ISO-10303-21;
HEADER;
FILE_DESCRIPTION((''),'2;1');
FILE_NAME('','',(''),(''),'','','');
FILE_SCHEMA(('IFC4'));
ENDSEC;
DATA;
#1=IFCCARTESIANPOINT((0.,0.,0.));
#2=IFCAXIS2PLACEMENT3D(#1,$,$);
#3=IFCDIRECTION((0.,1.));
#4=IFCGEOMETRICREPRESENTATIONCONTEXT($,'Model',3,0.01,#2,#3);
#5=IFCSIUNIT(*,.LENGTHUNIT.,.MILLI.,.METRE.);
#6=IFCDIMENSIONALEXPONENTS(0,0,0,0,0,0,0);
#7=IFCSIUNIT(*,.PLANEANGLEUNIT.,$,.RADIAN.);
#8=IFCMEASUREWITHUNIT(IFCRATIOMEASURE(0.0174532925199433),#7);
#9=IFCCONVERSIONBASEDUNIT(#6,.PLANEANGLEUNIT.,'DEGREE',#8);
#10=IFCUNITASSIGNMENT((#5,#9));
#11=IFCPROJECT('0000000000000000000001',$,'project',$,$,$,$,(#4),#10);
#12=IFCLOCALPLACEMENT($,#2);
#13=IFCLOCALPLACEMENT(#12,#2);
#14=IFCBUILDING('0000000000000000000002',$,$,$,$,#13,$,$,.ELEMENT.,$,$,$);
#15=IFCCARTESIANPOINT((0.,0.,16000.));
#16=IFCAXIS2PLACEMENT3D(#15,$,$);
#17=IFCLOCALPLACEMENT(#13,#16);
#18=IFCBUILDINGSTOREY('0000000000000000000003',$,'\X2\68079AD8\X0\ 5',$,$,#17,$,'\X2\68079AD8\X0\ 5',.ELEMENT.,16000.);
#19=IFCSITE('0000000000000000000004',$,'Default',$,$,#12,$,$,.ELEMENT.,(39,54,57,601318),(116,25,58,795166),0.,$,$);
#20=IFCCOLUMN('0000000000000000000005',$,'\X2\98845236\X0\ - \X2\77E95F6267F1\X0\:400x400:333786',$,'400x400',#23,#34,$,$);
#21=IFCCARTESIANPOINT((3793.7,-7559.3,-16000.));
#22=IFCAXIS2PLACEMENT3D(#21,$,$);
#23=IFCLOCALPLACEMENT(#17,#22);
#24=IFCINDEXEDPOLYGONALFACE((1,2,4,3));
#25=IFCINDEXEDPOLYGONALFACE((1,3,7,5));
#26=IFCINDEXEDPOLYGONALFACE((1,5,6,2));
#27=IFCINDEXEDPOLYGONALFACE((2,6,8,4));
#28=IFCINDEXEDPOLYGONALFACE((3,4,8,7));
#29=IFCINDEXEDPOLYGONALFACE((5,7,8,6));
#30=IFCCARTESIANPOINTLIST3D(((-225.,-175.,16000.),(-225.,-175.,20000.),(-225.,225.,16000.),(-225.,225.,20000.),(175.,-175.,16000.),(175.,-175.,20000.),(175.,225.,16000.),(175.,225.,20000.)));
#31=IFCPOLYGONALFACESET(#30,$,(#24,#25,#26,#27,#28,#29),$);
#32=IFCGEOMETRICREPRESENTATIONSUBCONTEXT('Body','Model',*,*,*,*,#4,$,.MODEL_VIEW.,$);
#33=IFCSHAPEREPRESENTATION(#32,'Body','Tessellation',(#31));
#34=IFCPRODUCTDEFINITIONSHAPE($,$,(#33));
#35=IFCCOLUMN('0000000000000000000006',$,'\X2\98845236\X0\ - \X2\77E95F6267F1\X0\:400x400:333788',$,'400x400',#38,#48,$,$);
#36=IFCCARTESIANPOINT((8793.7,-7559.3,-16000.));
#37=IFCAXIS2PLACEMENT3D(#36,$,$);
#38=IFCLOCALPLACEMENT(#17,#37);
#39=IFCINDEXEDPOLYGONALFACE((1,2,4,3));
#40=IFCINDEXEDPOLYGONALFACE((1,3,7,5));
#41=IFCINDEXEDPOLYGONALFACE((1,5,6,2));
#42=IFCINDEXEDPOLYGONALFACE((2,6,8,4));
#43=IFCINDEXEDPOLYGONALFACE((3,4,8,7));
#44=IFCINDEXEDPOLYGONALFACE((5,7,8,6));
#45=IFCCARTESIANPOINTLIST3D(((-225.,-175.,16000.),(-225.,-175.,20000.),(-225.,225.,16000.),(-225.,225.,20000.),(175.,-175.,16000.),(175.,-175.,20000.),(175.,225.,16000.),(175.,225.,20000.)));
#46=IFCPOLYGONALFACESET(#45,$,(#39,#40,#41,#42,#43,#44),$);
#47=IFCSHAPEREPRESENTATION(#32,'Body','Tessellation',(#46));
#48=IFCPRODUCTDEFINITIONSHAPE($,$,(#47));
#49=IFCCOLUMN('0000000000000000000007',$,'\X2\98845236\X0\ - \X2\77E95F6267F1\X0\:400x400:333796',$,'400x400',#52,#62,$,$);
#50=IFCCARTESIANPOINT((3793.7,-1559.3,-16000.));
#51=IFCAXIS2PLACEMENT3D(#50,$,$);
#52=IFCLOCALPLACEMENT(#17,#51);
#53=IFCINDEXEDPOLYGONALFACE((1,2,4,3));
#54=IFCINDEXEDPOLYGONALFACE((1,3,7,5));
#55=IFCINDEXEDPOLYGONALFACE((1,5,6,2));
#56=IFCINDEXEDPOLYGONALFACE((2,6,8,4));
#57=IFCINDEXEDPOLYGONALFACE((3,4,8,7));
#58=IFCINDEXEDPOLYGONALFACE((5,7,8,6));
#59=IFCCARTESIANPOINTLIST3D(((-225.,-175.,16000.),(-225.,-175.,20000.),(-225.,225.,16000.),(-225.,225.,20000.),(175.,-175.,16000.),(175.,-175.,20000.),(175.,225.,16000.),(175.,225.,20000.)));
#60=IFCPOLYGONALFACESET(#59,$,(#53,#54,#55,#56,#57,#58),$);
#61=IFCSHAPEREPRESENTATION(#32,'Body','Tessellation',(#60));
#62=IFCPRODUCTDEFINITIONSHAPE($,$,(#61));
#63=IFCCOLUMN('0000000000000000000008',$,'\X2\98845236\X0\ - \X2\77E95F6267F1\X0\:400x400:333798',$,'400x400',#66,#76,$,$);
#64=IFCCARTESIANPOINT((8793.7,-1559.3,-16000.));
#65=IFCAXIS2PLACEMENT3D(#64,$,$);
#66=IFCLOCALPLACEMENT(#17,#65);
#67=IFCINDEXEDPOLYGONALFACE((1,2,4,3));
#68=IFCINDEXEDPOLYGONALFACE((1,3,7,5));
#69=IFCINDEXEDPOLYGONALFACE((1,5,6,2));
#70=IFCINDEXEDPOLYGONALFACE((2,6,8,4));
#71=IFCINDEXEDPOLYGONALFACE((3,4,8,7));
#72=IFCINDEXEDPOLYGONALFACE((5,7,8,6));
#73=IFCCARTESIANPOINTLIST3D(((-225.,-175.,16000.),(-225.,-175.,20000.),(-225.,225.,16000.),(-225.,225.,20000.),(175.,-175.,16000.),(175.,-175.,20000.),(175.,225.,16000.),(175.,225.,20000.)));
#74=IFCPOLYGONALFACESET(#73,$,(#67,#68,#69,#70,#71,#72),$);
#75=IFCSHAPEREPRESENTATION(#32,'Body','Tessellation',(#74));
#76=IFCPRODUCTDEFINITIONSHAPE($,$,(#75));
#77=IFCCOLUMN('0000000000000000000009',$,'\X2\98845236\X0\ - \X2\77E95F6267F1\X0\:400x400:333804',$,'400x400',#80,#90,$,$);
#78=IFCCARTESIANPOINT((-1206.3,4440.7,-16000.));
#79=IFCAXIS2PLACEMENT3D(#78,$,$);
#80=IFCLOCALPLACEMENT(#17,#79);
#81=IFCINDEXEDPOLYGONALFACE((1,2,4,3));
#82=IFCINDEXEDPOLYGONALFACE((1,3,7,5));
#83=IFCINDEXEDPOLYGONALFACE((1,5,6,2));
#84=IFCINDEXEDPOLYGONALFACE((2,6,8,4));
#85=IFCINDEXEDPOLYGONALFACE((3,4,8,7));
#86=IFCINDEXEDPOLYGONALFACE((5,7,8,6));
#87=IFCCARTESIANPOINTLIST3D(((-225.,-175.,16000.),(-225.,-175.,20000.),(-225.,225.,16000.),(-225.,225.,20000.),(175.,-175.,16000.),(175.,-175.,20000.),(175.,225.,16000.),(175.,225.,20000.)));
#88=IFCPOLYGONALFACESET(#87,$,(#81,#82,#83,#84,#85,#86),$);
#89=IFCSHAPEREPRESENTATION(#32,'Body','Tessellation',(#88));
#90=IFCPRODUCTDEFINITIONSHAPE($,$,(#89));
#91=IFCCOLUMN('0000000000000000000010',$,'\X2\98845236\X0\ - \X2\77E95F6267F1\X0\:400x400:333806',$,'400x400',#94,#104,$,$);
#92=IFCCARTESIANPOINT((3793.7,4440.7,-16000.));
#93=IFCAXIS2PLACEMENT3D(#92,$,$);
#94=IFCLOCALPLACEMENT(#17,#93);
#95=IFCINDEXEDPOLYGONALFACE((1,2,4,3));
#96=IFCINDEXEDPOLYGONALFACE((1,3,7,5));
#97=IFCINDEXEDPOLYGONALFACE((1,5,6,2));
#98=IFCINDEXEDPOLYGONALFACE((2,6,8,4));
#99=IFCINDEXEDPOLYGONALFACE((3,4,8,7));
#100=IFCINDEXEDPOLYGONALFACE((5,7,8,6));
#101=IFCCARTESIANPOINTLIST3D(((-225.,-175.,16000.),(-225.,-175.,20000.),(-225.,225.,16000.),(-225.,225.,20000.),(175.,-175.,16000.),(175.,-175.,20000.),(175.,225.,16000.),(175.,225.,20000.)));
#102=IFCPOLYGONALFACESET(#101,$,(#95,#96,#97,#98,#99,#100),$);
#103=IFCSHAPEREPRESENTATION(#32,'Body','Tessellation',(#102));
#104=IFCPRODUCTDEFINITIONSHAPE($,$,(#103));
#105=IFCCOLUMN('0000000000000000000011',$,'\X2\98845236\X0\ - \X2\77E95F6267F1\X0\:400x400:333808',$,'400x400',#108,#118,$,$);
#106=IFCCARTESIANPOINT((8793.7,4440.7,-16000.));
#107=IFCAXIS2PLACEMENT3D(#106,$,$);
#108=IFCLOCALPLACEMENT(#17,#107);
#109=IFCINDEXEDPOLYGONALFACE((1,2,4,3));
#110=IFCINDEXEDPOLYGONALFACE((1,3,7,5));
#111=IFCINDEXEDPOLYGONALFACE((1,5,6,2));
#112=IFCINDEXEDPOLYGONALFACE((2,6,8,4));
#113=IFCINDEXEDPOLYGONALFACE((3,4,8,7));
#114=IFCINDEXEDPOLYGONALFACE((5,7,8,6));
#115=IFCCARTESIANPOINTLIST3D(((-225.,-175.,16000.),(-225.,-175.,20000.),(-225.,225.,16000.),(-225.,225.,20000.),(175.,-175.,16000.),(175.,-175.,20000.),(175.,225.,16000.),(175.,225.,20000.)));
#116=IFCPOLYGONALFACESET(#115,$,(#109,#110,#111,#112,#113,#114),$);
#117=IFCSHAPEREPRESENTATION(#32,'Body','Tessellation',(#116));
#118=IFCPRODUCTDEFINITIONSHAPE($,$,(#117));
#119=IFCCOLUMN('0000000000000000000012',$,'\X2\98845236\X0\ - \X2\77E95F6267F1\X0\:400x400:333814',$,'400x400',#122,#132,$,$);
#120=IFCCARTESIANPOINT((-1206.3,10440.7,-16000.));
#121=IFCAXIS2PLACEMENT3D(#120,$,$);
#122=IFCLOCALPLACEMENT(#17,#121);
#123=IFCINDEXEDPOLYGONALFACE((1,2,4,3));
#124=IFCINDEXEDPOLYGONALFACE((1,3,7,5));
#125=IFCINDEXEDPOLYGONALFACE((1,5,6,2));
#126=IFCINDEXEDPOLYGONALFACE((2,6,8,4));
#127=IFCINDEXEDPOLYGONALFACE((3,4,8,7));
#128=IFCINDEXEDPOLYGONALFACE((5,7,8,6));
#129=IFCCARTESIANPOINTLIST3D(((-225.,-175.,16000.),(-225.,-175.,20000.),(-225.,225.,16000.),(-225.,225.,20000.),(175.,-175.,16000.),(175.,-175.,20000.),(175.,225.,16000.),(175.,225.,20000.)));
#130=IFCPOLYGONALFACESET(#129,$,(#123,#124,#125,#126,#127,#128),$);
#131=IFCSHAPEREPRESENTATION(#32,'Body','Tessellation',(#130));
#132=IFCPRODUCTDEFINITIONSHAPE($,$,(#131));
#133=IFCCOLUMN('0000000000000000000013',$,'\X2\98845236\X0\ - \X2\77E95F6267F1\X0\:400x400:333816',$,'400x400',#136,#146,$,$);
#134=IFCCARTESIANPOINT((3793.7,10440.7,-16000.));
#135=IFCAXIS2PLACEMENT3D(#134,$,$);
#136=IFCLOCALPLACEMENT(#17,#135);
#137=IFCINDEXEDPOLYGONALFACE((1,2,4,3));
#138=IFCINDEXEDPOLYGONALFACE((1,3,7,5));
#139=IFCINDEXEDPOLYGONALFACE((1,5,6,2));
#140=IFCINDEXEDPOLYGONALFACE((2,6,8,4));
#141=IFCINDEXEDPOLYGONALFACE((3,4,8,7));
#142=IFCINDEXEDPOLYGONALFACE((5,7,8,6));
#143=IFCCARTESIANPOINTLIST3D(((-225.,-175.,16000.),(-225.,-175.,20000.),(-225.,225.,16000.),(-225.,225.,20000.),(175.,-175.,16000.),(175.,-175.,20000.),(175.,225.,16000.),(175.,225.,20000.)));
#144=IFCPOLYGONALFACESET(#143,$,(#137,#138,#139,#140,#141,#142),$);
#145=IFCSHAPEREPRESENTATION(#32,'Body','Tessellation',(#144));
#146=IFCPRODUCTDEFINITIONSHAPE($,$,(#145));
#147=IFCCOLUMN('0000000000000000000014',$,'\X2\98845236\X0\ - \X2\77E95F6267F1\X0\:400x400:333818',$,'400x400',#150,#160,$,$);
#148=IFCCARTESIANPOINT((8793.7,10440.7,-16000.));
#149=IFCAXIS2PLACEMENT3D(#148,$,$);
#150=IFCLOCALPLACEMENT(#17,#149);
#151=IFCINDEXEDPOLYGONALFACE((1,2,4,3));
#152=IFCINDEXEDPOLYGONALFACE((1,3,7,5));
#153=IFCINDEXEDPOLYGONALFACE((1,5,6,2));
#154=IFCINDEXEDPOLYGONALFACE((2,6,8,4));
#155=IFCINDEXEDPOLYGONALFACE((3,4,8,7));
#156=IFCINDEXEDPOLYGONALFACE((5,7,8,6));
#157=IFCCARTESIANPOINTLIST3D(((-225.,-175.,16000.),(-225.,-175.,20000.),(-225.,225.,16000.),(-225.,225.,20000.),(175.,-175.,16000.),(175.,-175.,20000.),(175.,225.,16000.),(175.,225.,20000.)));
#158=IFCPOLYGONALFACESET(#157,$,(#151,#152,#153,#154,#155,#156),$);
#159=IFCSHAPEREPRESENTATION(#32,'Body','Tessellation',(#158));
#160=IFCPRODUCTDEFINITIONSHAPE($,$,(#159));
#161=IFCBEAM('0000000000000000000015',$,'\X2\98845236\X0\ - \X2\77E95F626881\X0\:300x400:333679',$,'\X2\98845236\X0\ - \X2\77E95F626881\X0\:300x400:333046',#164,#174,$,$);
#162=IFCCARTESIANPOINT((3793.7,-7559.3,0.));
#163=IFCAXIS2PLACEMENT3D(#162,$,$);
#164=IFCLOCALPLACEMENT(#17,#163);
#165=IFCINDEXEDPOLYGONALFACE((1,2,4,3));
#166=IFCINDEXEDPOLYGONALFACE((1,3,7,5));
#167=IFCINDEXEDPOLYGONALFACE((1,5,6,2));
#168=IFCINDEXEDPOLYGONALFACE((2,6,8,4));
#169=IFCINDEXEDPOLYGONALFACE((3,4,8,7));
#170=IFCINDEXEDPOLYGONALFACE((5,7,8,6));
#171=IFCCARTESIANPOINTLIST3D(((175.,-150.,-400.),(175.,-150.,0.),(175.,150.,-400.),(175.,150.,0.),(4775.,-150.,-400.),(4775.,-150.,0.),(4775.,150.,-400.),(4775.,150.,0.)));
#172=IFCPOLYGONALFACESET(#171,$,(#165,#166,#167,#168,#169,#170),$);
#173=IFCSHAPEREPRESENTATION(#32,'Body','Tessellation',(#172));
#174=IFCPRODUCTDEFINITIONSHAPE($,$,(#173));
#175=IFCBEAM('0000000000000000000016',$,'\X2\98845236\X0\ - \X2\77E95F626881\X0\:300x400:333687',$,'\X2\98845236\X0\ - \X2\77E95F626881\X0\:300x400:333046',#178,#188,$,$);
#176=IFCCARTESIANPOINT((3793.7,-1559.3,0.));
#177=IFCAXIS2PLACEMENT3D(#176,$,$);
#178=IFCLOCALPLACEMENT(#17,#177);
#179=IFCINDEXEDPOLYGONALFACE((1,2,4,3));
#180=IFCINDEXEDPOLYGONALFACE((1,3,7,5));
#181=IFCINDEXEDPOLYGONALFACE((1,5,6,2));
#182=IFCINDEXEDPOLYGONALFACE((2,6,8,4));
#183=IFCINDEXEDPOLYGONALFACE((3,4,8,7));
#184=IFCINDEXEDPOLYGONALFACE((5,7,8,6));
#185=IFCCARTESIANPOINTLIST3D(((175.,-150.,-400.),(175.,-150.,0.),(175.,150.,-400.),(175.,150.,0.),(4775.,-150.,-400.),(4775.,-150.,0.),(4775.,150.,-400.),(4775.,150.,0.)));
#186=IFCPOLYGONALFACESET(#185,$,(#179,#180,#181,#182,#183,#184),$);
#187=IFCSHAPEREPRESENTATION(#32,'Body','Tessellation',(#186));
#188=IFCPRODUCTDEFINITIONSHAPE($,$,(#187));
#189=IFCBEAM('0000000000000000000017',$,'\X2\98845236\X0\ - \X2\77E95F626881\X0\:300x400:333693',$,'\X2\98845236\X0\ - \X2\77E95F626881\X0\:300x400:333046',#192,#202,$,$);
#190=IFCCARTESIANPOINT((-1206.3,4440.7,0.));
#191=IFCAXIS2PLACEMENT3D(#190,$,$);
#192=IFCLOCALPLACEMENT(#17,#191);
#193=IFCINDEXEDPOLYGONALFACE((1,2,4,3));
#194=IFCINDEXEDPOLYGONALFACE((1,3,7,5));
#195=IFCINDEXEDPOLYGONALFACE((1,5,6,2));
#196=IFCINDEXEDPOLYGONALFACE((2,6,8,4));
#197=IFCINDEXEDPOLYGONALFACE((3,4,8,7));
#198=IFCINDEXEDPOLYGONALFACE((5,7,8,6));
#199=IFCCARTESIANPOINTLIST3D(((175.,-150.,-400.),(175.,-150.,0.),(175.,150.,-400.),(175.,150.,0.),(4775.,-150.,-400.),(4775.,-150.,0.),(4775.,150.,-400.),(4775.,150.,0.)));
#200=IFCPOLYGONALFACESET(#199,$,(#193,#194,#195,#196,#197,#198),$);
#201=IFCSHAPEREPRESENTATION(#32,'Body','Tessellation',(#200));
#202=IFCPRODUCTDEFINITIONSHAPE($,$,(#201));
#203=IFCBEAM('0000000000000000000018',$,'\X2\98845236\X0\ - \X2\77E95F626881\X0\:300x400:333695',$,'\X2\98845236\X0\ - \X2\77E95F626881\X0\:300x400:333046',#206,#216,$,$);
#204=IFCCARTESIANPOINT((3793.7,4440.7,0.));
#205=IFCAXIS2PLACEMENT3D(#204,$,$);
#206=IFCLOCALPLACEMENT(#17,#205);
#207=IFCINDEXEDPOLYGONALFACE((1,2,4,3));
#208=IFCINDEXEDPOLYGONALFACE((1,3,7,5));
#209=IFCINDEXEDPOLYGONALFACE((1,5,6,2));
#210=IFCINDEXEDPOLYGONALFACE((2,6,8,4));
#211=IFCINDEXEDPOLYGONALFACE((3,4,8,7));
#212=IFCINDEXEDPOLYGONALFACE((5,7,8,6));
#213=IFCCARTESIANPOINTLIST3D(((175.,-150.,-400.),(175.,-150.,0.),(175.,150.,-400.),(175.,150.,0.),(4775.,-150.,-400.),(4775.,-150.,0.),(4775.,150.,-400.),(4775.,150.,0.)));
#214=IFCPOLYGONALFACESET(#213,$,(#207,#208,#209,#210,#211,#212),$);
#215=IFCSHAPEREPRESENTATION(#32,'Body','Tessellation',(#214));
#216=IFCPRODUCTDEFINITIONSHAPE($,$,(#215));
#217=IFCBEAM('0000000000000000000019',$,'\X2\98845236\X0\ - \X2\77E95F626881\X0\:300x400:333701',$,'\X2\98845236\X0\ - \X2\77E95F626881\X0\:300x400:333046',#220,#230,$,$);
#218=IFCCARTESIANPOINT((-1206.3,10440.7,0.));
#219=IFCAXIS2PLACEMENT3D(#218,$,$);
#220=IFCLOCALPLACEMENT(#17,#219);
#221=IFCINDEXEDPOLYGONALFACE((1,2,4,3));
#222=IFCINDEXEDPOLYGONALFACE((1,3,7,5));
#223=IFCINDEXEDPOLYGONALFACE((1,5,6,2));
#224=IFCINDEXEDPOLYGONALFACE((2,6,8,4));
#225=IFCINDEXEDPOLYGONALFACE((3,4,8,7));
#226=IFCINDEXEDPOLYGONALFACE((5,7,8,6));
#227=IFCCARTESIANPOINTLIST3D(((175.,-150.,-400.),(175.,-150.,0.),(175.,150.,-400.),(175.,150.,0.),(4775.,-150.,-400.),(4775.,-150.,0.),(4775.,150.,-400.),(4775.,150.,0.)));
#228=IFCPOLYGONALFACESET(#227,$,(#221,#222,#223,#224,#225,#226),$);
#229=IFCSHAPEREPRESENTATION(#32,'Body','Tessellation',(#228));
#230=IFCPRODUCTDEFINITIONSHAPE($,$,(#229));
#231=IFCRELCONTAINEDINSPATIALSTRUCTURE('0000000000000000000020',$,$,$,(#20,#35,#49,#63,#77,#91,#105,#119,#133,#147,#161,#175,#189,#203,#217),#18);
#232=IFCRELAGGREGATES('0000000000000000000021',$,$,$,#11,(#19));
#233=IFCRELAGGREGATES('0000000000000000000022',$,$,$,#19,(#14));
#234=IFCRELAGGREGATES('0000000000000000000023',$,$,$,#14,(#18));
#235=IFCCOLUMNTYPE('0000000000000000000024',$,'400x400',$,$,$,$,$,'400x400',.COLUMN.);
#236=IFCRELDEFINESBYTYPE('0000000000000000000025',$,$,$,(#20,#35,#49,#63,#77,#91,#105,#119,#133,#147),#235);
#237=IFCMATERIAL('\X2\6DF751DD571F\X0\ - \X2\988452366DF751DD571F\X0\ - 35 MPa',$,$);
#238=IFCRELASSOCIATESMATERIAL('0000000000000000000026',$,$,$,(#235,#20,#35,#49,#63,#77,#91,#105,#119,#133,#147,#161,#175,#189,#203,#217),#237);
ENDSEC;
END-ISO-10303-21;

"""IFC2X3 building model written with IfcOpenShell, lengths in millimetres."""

from ifc_helpers import new_model, entity, si_unit, converted_unit, direction, frame, frame_2d, origin, place, context, subcontext, project, spatial, rectangle, extrude, source, transform, mapped, material, type_object, type_shapes, element, save


model = new_model("IFC2X3")

# Units and contexts
model_context = context("Model", 3, precision=0.01, world=origin(), true_north=direction((0.0, 1.0)))
body_context = subcontext(model_context, "Body", "Model", "MODEL_VIEW")
ifc_project = project(units=[si_unit("LENGTHUNIT", "METRE", prefix="MILLI"), converted_unit("PLANEANGLEUNIT", "DEGREE", entity("IfcRatioMeasure", 0.0174532925199433), si_unit("PLANEANGLEUNIT", "RADIAN"), dimensions=[0, 0, 0, 0, 0, 0, 0])], contexts=[model_context])

# Site, building, storey
site_placement = place(None, origin())
site = spatial("IfcSite", under=ifc_project, at=site_placement, Name="Default", CompositionType="ELEMENT", RefLatitude=(39, 54, 57, 601318), RefLongitude=(116, 25, 58, 795166), RefElevation=0.0)
building_placement = place(site_placement, origin())
building = spatial("IfcBuilding", under=site, at=building_placement, CompositionType="ELEMENT")
storey_placement = place(building_placement, frame((0.0, 0.0, 16000.0)))
storey = spatial("IfcBuildingStorey", under=building, at=storey_placement, Name="标高 5", LongName="标高 5", CompositionType="ELEMENT", Elevation=16000.0)

# Columns
ifc_material_1 = material(Name="混凝土 - 预制混凝土 - 35 MPa")
column_type = type_object("IfcColumnType", Name="400x400", ElementType="400x400", PredefinedType="COLUMN", material=ifc_material_1)
shared_shape = source(origin(), body_context, "Body", "SweptSolid", [
    extrude(rectangle(XDim=400.0, YDim=400.0, at=frame_2d((0.0, 0.0), x_axis=(1.0, 0.0))), frame((-25.0, 25.0, 16000.0)), (0.0, 0.0, 1.0), 4000.0),
])
type_shapes(column_type, [shared_shape])
for number, where, name in (
    (1, (3793.7, -7559.3, -16000.0), "预制 - 矩形柱:400x400:333786"),
    (2, (8793.7, -7559.3, -16000.0), "预制 - 矩形柱:400x400:333788"),
    (3, (3793.7, -1559.3, -16000.0), "预制 - 矩形柱:400x400:333796"),
    (4, (8793.7, -1559.3, -16000.0), "预制 - 矩形柱:400x400:333798"),
    (5, (-1206.3, 4440.7, -16000.0), "预制 - 矩形柱:400x400:333804"),
    (6, (3793.7, 4440.7, -16000.0), "预制 - 矩形柱:400x400:333806"),
    (7, (8793.7, 4440.7, -16000.0), "预制 - 矩形柱:400x400:333808"),
    (8, (-1206.3, 10440.7, -16000.0), "预制 - 矩形柱:400x400:333814"),
    (9, (3793.7, 10440.7, -16000.0), "预制 - 矩形柱:400x400:333816"),
    (10, (8793.7, 10440.7, -16000.0), "预制 - 矩形柱:400x400:333818"),
):
    element("IfcColumn", number, at=place(storey_placement, frame(where)), inside=storey, type_object=column_type, material=ifc_material_1, Name=name, ObjectType="400x400", context=body_context, shape_type="MappedRepresentation", body=[
        mapped(shared_shape, transform((0.0, 0.0, 0.0), scale=1.0)),
    ])

# Beams
beam_1_placement = place(storey_placement, frame((3793.7, -7559.3, 0.0)))
element("IfcBeam", 11, at=beam_1_placement, inside=storey, material=ifc_material_1, Name="预制 - 矩形梁:300x400:333679", ObjectType="预制 - 矩形梁:300x400:333046", context=body_context, shape_type="SweptSolid", body=[
    extrude(rectangle(XDim=400.0, YDim=300.0, at=frame_2d((0.0, 0.0), x_axis=(1.0, 0.0))), frame((175.0, 0.0, -200.0), z_axis=(1.0, 0.0, 0.0), x_axis=(0.0, 0.0, -1.0)), (0.0, 0.0, 1.0), 4600.0),
])
beam_2_placement = place(storey_placement, frame((3793.7, -1559.3, 0.0)))
element("IfcBeam", 12, at=beam_2_placement, inside=storey, material=ifc_material_1, Name="预制 - 矩形梁:300x400:333687", ObjectType="预制 - 矩形梁:300x400:333046", context=body_context, shape_type="SweptSolid", body=[
    extrude(rectangle(XDim=400.0, YDim=300.0, at=frame_2d((0.0, 0.0), x_axis=(1.0, 0.0))), frame((175.0, 0.0, -200.0), z_axis=(1.0, 0.0, 0.0), x_axis=(0.0, 0.0, -1.0)), (0.0, 0.0, 1.0), 4600.0),
])
beam_3_placement = place(storey_placement, frame((-1206.3, 4440.7, 0.0)))
element("IfcBeam", 13, at=beam_3_placement, inside=storey, material=ifc_material_1, Name="预制 - 矩形梁:300x400:333693", ObjectType="预制 - 矩形梁:300x400:333046", context=body_context, shape_type="SweptSolid", body=[
    extrude(rectangle(XDim=400.0, YDim=300.0, at=frame_2d((0.0, 0.0), x_axis=(1.0, 0.0))), frame((175.0, 0.0, -200.0), z_axis=(1.0, 0.0, 0.0), x_axis=(0.0, 0.0, -1.0)), (0.0, 0.0, 1.0), 4600.0),
])
beam_4_placement = place(storey_placement, frame((3793.7, 4440.7, 0.0)))
element("IfcBeam", 14, at=beam_4_placement, inside=storey, material=ifc_material_1, Name="预制 - 矩形梁:300x400:333695", ObjectType="预制 - 矩形梁:300x400:333046", context=body_context, shape_type="SweptSolid", body=[
    extrude(rectangle(XDim=400.0, YDim=300.0, at=frame_2d((0.0, 0.0), x_axis=(1.0, 0.0))), frame((175.0, 0.0, -200.0), z_axis=(1.0, 0.0, 0.0), x_axis=(0.0, 0.0, -1.0)), (0.0, 0.0, 1.0), 4600.0),
])
beam_5_placement = place(storey_placement, frame((-1206.3, 10440.7, 0.0)))
element("IfcBeam", 15, at=beam_5_placement, inside=storey, material=ifc_material_1, Name="预制 - 矩形梁:300x400:333701", ObjectType="预制 - 矩形梁:300x400:333046", context=body_context, shape_type="SweptSolid", body=[
    extrude(rectangle(XDim=400.0, YDim=300.0, at=frame_2d((0.0, 0.0), x_axis=(1.0, 0.0))), frame((175.0, 0.0, -200.0), z_axis=(1.0, 0.0, 0.0), x_axis=(0.0, 0.0, -1.0)), (0.0, 0.0, 1.0), 4600.0),
])

save(model, "model.ifc")
